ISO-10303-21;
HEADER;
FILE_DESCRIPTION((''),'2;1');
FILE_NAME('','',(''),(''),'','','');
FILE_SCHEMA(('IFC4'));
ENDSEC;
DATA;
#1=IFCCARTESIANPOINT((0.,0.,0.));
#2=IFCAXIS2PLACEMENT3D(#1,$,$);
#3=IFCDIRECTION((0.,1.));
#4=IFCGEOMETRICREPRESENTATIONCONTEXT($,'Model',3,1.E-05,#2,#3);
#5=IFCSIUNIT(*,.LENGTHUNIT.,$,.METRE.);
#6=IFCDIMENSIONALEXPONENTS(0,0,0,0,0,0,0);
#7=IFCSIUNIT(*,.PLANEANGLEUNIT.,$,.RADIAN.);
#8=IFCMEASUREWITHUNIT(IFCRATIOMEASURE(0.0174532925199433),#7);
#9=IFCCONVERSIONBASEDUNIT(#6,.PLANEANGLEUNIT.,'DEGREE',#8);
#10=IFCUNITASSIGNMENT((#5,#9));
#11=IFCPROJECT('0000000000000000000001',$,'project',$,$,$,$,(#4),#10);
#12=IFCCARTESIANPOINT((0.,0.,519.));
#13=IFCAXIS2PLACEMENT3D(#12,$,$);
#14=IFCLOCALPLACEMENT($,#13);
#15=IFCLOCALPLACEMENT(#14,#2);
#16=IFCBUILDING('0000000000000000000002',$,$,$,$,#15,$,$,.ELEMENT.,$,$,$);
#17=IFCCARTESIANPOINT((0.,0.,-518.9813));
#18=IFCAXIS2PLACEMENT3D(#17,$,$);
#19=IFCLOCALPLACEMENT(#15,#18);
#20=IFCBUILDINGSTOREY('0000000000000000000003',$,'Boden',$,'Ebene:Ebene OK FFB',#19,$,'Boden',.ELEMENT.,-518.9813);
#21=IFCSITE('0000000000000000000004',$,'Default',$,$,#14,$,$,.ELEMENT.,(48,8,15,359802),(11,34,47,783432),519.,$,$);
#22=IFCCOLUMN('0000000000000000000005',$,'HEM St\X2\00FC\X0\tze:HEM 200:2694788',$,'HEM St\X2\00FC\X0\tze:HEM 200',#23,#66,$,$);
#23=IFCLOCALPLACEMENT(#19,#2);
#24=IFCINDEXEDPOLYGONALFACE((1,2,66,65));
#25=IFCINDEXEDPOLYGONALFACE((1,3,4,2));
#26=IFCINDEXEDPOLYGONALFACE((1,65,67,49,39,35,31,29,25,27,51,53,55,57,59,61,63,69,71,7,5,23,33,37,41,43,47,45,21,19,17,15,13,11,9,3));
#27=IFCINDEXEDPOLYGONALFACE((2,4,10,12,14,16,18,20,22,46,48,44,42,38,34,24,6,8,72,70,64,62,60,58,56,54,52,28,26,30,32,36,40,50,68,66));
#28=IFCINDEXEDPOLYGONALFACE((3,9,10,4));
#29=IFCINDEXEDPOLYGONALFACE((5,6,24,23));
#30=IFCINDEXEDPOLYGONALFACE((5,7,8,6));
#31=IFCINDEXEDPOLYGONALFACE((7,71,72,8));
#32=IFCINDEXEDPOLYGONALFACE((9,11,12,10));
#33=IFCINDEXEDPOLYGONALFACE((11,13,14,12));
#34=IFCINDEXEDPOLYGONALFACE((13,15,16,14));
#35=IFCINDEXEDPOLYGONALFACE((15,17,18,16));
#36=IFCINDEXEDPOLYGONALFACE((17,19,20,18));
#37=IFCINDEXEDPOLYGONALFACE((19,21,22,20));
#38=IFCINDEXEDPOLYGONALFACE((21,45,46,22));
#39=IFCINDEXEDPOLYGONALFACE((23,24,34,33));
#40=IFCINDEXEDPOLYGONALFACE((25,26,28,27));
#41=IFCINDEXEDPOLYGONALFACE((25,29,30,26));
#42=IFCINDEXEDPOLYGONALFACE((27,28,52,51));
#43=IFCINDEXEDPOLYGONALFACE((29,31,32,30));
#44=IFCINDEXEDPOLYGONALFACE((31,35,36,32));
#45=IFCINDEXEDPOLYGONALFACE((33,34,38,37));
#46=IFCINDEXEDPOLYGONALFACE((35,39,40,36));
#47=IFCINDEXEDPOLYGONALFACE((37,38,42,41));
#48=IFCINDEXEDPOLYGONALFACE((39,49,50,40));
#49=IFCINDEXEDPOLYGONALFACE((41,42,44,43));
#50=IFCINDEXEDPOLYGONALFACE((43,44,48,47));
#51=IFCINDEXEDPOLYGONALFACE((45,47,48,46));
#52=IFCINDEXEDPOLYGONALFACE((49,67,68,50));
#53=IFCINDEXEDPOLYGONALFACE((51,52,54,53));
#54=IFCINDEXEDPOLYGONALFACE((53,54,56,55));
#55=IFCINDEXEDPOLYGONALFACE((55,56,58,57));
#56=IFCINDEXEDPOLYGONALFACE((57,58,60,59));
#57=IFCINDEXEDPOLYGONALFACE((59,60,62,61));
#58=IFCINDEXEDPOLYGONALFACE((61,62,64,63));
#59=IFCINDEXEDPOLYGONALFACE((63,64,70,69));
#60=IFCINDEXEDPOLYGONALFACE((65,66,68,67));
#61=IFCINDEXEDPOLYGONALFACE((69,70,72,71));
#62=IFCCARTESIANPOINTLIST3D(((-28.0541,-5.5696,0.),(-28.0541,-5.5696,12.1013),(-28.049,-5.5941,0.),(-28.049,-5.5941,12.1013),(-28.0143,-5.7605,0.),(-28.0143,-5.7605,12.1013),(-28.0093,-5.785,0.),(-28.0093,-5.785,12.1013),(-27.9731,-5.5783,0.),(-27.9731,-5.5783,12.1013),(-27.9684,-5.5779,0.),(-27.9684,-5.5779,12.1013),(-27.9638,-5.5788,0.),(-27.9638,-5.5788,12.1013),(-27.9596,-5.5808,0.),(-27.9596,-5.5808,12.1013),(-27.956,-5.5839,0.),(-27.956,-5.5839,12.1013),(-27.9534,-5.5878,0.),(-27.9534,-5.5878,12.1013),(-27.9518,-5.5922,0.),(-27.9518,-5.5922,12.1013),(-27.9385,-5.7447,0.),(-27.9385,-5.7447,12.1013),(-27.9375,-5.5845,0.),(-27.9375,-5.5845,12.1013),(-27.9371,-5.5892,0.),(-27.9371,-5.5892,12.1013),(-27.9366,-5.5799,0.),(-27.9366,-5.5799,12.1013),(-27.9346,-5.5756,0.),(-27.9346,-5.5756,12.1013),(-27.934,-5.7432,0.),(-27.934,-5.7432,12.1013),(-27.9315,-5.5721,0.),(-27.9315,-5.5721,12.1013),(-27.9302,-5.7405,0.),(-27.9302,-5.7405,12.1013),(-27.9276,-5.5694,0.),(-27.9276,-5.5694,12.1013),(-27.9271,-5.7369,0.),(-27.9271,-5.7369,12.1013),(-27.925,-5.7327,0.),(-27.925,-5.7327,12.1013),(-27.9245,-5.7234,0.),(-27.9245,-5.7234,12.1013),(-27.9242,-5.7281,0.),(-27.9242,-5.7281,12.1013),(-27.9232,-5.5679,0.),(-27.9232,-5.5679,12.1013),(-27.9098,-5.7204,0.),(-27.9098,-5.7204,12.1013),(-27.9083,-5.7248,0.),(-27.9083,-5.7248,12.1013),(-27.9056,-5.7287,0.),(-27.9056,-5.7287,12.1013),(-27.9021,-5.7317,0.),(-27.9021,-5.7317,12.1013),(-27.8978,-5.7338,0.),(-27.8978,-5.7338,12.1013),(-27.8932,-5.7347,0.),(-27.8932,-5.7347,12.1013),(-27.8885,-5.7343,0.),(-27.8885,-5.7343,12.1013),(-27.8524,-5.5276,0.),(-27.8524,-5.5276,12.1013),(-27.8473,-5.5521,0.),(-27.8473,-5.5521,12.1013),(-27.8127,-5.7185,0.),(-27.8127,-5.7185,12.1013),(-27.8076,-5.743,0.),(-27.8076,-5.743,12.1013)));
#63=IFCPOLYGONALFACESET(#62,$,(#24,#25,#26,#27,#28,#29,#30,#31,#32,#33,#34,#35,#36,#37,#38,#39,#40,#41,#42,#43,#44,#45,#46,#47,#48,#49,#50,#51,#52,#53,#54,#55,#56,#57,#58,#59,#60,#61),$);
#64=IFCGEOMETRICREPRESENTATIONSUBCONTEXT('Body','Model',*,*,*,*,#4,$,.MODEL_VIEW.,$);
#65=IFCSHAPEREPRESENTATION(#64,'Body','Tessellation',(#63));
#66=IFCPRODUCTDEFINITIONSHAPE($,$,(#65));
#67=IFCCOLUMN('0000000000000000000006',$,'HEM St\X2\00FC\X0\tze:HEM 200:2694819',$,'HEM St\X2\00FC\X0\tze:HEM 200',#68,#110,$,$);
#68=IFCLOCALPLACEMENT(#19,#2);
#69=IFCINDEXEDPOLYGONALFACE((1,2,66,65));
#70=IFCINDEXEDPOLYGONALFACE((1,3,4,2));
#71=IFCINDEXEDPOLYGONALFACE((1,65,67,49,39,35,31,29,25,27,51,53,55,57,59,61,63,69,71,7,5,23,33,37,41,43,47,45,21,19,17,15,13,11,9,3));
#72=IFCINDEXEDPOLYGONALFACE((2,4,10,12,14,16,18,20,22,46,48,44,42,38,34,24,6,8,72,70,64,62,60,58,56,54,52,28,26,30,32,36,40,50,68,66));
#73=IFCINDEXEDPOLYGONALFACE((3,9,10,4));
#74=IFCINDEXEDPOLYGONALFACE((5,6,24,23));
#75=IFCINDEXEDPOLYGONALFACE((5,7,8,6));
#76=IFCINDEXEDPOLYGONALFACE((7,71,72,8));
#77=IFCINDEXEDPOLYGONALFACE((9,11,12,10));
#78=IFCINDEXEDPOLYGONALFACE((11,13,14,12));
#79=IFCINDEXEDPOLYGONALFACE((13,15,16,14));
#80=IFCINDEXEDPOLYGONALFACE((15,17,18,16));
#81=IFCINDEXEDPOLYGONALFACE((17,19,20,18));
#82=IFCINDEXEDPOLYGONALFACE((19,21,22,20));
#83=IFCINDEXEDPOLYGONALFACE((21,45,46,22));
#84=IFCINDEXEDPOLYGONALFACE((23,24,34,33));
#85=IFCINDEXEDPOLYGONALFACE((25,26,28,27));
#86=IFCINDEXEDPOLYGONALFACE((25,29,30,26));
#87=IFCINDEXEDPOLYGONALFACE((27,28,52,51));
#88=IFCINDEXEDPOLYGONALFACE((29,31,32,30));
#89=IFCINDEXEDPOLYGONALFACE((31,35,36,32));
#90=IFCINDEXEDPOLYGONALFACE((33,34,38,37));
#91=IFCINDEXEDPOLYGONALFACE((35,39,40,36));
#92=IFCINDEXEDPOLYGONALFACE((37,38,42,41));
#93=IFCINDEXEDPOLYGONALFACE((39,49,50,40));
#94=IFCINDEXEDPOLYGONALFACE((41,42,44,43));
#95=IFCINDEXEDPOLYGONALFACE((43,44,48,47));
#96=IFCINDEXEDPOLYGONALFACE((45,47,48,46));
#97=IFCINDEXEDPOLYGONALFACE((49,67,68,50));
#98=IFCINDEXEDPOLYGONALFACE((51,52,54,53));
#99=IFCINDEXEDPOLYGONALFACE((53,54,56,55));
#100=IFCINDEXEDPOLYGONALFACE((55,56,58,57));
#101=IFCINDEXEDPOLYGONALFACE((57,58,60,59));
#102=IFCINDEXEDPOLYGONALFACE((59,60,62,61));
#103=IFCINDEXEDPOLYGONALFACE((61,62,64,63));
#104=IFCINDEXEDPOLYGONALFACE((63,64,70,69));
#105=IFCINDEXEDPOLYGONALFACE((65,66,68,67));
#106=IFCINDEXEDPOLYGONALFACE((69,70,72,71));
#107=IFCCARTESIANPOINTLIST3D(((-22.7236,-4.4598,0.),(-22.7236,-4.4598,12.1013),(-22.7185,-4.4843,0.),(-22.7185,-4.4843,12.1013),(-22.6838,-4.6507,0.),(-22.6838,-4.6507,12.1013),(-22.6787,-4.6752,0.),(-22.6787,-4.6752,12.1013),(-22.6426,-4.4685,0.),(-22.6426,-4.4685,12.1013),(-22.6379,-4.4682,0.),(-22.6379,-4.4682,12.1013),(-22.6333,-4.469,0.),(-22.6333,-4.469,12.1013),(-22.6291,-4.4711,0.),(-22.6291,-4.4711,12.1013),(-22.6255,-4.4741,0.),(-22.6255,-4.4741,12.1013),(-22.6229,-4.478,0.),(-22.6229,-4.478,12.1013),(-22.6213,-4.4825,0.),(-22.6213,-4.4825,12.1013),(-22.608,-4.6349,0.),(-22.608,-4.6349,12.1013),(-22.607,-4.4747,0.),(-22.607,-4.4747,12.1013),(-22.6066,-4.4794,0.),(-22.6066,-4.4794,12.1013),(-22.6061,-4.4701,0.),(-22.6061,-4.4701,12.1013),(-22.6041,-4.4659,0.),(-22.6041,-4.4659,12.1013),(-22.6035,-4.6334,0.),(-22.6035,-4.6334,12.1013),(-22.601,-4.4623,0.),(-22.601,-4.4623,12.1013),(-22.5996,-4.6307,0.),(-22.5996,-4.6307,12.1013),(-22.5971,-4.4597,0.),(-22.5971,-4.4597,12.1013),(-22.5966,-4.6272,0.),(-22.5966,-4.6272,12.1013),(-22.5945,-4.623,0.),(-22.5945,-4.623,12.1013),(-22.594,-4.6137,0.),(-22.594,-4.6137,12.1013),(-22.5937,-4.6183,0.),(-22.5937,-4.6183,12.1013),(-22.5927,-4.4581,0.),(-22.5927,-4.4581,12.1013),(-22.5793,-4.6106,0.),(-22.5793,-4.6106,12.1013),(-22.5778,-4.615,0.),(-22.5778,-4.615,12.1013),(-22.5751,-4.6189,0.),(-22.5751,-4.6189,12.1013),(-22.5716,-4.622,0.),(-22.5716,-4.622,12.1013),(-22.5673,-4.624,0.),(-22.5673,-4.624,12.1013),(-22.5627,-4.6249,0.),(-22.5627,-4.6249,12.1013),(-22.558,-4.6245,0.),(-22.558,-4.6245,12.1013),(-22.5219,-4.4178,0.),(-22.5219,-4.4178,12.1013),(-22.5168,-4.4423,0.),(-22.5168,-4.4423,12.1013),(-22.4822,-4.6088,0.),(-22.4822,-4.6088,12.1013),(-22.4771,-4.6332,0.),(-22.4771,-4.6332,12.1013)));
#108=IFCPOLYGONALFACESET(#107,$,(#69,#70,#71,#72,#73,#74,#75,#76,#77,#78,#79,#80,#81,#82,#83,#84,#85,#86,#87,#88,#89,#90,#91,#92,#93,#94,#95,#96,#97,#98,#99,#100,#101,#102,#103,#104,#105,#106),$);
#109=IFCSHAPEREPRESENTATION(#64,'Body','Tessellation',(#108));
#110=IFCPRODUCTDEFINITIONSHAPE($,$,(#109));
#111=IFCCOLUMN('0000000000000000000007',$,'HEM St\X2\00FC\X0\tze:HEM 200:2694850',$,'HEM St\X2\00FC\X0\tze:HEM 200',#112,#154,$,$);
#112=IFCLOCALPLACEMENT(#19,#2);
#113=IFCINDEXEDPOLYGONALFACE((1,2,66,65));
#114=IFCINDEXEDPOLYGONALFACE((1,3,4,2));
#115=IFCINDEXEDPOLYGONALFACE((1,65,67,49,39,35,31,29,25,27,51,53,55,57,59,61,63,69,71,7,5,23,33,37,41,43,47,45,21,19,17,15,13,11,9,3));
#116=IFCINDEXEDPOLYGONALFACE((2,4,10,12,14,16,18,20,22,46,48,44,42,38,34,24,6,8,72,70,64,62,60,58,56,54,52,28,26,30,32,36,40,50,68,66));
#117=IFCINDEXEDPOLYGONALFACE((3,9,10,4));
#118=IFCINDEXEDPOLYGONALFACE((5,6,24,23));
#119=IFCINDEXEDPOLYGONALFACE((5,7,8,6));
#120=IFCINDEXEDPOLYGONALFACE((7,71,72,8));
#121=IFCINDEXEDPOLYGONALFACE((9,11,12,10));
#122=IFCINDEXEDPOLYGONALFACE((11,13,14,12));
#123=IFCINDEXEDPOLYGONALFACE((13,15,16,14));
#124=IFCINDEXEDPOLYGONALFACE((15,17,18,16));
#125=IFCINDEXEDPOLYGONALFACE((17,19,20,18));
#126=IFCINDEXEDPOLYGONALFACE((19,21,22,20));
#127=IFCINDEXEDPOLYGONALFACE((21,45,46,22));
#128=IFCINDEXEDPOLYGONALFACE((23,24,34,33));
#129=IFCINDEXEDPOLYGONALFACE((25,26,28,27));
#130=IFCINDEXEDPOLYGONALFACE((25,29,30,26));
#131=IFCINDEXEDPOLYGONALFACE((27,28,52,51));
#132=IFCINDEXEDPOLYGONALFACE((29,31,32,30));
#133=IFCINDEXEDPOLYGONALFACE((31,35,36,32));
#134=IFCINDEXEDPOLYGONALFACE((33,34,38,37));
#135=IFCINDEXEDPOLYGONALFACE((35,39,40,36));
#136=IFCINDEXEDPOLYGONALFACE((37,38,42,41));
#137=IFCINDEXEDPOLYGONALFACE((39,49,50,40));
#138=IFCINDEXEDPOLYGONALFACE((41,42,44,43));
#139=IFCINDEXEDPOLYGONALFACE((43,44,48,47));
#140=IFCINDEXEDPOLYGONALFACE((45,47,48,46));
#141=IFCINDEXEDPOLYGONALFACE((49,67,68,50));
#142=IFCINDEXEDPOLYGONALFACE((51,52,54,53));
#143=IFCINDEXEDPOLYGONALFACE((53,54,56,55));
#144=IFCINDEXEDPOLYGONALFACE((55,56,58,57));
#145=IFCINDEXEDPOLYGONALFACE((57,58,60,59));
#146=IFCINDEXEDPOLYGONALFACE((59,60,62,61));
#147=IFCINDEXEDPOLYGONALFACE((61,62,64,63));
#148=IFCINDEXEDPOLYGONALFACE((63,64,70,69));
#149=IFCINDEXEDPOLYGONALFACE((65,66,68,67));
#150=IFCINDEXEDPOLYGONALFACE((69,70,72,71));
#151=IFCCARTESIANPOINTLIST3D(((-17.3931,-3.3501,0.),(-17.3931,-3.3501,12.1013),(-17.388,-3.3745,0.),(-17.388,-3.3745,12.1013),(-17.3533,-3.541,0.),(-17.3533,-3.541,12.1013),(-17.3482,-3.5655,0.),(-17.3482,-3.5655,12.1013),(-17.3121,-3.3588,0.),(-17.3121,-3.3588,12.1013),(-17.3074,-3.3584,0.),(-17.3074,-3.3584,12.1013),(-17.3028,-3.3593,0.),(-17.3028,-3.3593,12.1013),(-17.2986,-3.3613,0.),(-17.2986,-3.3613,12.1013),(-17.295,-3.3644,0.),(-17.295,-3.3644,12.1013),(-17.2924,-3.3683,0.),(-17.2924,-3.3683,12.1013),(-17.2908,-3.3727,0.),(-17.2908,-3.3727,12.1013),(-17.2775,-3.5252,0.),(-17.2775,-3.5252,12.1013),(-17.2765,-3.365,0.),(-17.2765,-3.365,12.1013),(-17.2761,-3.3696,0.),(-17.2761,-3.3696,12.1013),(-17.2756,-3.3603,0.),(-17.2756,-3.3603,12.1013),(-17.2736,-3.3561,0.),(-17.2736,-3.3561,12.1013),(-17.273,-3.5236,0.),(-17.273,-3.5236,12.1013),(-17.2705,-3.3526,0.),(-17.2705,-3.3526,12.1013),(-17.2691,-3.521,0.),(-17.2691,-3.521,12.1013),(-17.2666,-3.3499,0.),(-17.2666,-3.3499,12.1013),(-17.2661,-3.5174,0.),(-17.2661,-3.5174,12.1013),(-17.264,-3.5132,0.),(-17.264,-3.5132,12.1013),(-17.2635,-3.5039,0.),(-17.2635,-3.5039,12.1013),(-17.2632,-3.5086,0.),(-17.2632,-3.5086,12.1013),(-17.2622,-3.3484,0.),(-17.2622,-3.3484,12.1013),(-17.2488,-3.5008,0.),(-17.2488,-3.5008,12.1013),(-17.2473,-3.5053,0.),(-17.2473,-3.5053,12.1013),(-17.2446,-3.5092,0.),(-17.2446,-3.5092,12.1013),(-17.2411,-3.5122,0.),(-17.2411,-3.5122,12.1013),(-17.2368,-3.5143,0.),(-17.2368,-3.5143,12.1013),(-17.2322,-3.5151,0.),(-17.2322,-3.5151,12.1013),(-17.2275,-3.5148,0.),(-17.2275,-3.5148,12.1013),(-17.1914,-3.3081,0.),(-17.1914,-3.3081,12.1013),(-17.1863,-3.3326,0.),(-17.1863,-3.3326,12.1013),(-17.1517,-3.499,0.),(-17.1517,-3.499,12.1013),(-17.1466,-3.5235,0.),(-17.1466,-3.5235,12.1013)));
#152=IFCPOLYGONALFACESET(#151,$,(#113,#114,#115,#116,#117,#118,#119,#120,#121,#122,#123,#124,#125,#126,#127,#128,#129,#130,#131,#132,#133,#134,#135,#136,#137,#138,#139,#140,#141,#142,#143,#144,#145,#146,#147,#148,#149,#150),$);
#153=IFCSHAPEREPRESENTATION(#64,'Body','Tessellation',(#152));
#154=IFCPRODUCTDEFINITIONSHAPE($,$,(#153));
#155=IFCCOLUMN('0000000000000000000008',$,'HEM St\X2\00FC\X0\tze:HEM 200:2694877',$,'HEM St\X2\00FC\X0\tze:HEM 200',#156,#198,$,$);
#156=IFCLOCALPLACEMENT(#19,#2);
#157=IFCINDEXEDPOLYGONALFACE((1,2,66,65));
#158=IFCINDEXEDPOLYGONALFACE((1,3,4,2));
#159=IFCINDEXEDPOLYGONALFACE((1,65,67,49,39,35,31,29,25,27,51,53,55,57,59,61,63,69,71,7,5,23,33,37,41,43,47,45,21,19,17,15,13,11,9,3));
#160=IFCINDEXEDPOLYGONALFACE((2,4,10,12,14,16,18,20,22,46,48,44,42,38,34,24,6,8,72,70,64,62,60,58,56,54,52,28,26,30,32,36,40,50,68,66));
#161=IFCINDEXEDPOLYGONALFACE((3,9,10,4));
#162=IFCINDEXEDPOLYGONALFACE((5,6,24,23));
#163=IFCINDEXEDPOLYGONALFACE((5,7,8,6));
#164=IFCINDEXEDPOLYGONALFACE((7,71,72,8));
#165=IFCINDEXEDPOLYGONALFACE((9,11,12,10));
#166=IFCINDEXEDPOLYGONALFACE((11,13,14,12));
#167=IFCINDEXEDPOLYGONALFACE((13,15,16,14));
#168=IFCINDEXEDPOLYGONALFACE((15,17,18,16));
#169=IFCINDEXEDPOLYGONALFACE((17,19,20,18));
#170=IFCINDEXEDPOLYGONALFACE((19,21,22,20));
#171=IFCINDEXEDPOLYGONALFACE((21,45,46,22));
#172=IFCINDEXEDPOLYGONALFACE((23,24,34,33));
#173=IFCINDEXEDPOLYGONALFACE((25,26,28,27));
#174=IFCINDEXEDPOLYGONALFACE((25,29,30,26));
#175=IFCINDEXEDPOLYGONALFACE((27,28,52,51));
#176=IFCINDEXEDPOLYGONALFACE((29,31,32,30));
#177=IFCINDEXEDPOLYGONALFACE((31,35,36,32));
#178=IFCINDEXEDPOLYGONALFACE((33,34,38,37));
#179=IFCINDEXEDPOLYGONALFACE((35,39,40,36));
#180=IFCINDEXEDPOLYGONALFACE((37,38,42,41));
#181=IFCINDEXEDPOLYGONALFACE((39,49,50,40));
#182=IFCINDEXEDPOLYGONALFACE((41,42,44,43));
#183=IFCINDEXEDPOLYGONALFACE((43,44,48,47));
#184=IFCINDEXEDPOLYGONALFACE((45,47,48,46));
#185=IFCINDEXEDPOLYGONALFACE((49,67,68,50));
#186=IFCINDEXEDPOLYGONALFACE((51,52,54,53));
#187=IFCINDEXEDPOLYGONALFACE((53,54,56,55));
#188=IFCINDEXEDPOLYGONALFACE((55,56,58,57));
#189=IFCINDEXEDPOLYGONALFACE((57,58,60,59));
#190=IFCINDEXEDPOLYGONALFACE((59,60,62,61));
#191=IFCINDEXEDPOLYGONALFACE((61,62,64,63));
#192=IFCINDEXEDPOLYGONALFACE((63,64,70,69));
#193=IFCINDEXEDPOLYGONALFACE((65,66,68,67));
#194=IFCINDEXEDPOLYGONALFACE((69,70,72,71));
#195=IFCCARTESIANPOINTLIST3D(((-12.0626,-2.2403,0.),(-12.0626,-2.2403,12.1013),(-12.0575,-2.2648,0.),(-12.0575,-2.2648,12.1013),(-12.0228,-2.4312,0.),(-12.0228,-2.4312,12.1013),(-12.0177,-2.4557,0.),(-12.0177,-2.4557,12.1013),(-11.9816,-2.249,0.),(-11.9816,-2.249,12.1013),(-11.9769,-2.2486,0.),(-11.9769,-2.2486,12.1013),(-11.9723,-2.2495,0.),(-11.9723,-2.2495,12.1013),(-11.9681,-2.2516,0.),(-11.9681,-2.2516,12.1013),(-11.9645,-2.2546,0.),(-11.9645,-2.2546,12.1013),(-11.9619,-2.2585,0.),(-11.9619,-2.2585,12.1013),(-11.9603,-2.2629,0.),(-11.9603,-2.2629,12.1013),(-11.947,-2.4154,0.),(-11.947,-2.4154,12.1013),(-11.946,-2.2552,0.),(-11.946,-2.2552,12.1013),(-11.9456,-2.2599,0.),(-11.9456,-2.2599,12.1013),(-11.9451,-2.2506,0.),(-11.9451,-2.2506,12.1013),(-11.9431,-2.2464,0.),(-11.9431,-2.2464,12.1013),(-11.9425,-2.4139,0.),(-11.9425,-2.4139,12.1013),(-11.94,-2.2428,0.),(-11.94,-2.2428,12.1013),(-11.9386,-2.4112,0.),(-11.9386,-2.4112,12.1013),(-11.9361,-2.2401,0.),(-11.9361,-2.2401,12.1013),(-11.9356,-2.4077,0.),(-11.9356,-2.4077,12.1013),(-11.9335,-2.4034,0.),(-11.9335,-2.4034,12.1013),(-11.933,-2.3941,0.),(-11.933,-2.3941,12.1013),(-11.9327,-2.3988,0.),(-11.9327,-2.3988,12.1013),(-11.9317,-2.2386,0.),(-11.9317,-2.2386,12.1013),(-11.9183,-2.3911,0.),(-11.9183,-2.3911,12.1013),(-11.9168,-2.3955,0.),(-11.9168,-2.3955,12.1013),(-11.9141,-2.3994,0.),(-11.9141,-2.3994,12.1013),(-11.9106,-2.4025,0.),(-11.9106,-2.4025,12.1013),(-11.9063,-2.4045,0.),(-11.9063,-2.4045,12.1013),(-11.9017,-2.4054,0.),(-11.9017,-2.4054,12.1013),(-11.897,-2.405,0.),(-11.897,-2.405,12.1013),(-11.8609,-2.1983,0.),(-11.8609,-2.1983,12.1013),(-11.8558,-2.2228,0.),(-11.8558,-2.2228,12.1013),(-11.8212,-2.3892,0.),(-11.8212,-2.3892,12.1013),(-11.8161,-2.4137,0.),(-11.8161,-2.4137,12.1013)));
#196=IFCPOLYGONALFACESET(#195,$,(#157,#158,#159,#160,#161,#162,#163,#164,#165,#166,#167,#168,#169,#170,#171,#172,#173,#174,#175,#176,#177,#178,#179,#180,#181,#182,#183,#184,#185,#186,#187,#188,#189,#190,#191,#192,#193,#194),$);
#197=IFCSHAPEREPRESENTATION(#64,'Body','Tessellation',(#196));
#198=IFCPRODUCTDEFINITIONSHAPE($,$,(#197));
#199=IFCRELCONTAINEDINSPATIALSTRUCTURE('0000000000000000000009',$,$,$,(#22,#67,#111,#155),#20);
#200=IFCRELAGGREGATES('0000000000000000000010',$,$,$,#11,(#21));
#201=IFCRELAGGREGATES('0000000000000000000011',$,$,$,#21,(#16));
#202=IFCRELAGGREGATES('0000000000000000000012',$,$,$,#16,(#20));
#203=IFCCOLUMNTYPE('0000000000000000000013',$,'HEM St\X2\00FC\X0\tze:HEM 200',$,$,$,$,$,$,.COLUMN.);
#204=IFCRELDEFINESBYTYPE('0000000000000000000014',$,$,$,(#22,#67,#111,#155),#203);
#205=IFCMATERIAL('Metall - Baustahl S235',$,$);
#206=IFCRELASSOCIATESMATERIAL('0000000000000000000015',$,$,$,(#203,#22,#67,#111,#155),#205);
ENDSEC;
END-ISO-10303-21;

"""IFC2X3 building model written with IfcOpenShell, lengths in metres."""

from ifc_helpers import new_model, entity, si_unit, converted_unit, direction, frame, frame_2d, origin, place, context, subcontext, project, spatial, polyline, circle_curve, parameter, trimmed, segment, composite_curve, outline, extrude, source, transform, mapped, material, type_object, type_shapes, element, save


model = new_model("IFC2X3")

# Units and contexts
model_context = context("Model", 3, precision=1e-05, world=origin(), true_north=direction((0.0, 1.0)))
body_context = subcontext(model_context, "Body", "Model", "MODEL_VIEW")
ifc_project = project(units=[si_unit("LENGTHUNIT", "METRE"), converted_unit("PLANEANGLEUNIT", "DEGREE", entity("IfcRatioMeasure", 0.0174532925199433), si_unit("PLANEANGLEUNIT", "RADIAN"), dimensions=[0, 0, 0, 0, 0, 0, 0])], contexts=[model_context])

# Site, building, storey
site_placement = place(None, frame((0.0, 0.0, 519.0)))
site = spatial("IfcSite", under=ifc_project, at=site_placement, Name="Default", CompositionType="ELEMENT", RefLatitude=(48, 8, 15, 359802), RefLongitude=(11, 34, 47, 783432), RefElevation=519.0)
building_placement = place(site_placement, origin())
building = spatial("IfcBuilding", under=site, at=building_placement, CompositionType="ELEMENT")
storey_placement = place(building_placement, frame((0.0, 0.0, -518.9813)))
storey = spatial("IfcBuildingStorey", under=building, at=storey_placement, Name="Boden", ObjectType="Ebene:Ebene OK FFB", LongName="Boden", CompositionType="ELEMENT", Elevation=-518.9813)

# Columns
ifc_material_1 = material(Name="Metall - Baustahl S235")
column_type_1 = type_object("IfcColumnType", Name="HEM Stütze:HEM 200", PredefinedType="COLUMN", material=ifc_material_1)
shared_shape_1 = source(origin(), body_context, "Body", "SweptSolid", [
    extrude(outline(composite_curve([segment(polyline([(0.085, -0.103), (0.11, -0.103)]), True, "CONTINUOUS"), segment(polyline([(0.11, -0.103), (0.11, 0.103)]), True, "CONTINUOUS"), segment(polyline([(0.11, 0.103), (0.085, 0.103)]), True, "CONTINUOUS"), segment(polyline([(0.085, 0.103), (0.085, 0.0255)]), True, "CONTINUOUS"), segment(trimmed(circle_curve(frame_2d((0.067, 0.0255), x_axis=(1.0, 0.0)), 0.018), [parameter(270.0)], [parameter(0.0)], True, "PARAMETER"), False, "CONTINUOUS"), segment(polyline([(0.067, 0.0075), (-0.067, 0.0075)]), True, "CONTINUOUS"), segment(trimmed(circle_curve(frame_2d((-0.067, 0.0255), x_axis=(0.0, -1.0)), 0.018), [parameter(270.0)], [parameter(0.0)], True, "PARAMETER"), False, "CONTINUOUS"), segment(polyline([(-0.085, 0.0255), (-0.085, 0.103)]), True, "CONTINUOUS"), segment(polyline([(-0.085, 0.103), (-0.11, 0.103)]), True, "CONTINUOUS"), segment(polyline([(-0.11, 0.103), (-0.11, -0.103)]), True, "CONTINUOUS"), segment(polyline([(-0.11, -0.103), (-0.085, -0.103)]), True, "CONTINUOUS"), segment(polyline([(-0.085, -0.103), (-0.085, -0.0255)]), True, "CONTINUOUS"), segment(trimmed(circle_curve(frame_2d((-0.067, -0.0255), x_axis=(-1.0, 0.0)), 0.018), [parameter(270.0)], [parameter(0.0)], True, "PARAMETER"), False, "CONTINUOUS"), segment(polyline([(-0.067, -0.0075), (0.067, -0.0075)]), True, "CONTINUOUS"), segment(trimmed(circle_curve(frame_2d((0.067, -0.0255), x_axis=(0.0, 1.0)), 0.018), [parameter(270.0)], [parameter(0.0)], True, "PARAMETER"), False, "CONTINUOUS"), segment(polyline([(0.085, -0.0255), (0.085, -0.103)]), True, "CONTINUOUS")], self_intersect=False)), frame((0.0, 0.0, -518.9813), z_axis=(0.0, 0.0, 1.0), x_axis=(0.0, -1.0, 0.0)), (0.0, 0.0, 1.0), 12.1013),
])
type_shapes(column_type_1, [shared_shape_1])
for number, where, z_axis, x_axis, name in (
    (1, (-27.9308, -5.6563, 518.9813), (0.0, 0.0, 1.0), (0.979008, 0.20382, 0.0), "HEM Stütze:HEM 200:2694788"),
    (2, (-22.6003, -4.5465, 518.9813), (0.0, 0.0, 1.0), (0.979008, 0.20382, 0.0), "HEM Stütze:HEM 200:2694819"),
    (3, (-17.2698, -3.4368, 518.9813), (0.0, 0.0, 1.0), (0.979008, 0.20382, 0.0), "HEM Stütze:HEM 200:2694850"),
    (4, (-11.9393, -2.327, 518.9813), (0.0, 0.0, 1.0), (0.979008, 0.20382, 0.0), "HEM Stütze:HEM 200:2694877"),
):
    element("IfcColumn", number, at=place(storey_placement, frame(where, z_axis=z_axis, x_axis=x_axis)), inside=storey, type_object=column_type_1, material=ifc_material_1, Name=name, ObjectType="HEM Stütze:HEM 200", context=body_context, shape_type="MappedRepresentation", body=[
        mapped(shared_shape_1, transform((0.0, 0.0, 0.0), scale=1.0)),
    ])

save(model, "model.ifc")
